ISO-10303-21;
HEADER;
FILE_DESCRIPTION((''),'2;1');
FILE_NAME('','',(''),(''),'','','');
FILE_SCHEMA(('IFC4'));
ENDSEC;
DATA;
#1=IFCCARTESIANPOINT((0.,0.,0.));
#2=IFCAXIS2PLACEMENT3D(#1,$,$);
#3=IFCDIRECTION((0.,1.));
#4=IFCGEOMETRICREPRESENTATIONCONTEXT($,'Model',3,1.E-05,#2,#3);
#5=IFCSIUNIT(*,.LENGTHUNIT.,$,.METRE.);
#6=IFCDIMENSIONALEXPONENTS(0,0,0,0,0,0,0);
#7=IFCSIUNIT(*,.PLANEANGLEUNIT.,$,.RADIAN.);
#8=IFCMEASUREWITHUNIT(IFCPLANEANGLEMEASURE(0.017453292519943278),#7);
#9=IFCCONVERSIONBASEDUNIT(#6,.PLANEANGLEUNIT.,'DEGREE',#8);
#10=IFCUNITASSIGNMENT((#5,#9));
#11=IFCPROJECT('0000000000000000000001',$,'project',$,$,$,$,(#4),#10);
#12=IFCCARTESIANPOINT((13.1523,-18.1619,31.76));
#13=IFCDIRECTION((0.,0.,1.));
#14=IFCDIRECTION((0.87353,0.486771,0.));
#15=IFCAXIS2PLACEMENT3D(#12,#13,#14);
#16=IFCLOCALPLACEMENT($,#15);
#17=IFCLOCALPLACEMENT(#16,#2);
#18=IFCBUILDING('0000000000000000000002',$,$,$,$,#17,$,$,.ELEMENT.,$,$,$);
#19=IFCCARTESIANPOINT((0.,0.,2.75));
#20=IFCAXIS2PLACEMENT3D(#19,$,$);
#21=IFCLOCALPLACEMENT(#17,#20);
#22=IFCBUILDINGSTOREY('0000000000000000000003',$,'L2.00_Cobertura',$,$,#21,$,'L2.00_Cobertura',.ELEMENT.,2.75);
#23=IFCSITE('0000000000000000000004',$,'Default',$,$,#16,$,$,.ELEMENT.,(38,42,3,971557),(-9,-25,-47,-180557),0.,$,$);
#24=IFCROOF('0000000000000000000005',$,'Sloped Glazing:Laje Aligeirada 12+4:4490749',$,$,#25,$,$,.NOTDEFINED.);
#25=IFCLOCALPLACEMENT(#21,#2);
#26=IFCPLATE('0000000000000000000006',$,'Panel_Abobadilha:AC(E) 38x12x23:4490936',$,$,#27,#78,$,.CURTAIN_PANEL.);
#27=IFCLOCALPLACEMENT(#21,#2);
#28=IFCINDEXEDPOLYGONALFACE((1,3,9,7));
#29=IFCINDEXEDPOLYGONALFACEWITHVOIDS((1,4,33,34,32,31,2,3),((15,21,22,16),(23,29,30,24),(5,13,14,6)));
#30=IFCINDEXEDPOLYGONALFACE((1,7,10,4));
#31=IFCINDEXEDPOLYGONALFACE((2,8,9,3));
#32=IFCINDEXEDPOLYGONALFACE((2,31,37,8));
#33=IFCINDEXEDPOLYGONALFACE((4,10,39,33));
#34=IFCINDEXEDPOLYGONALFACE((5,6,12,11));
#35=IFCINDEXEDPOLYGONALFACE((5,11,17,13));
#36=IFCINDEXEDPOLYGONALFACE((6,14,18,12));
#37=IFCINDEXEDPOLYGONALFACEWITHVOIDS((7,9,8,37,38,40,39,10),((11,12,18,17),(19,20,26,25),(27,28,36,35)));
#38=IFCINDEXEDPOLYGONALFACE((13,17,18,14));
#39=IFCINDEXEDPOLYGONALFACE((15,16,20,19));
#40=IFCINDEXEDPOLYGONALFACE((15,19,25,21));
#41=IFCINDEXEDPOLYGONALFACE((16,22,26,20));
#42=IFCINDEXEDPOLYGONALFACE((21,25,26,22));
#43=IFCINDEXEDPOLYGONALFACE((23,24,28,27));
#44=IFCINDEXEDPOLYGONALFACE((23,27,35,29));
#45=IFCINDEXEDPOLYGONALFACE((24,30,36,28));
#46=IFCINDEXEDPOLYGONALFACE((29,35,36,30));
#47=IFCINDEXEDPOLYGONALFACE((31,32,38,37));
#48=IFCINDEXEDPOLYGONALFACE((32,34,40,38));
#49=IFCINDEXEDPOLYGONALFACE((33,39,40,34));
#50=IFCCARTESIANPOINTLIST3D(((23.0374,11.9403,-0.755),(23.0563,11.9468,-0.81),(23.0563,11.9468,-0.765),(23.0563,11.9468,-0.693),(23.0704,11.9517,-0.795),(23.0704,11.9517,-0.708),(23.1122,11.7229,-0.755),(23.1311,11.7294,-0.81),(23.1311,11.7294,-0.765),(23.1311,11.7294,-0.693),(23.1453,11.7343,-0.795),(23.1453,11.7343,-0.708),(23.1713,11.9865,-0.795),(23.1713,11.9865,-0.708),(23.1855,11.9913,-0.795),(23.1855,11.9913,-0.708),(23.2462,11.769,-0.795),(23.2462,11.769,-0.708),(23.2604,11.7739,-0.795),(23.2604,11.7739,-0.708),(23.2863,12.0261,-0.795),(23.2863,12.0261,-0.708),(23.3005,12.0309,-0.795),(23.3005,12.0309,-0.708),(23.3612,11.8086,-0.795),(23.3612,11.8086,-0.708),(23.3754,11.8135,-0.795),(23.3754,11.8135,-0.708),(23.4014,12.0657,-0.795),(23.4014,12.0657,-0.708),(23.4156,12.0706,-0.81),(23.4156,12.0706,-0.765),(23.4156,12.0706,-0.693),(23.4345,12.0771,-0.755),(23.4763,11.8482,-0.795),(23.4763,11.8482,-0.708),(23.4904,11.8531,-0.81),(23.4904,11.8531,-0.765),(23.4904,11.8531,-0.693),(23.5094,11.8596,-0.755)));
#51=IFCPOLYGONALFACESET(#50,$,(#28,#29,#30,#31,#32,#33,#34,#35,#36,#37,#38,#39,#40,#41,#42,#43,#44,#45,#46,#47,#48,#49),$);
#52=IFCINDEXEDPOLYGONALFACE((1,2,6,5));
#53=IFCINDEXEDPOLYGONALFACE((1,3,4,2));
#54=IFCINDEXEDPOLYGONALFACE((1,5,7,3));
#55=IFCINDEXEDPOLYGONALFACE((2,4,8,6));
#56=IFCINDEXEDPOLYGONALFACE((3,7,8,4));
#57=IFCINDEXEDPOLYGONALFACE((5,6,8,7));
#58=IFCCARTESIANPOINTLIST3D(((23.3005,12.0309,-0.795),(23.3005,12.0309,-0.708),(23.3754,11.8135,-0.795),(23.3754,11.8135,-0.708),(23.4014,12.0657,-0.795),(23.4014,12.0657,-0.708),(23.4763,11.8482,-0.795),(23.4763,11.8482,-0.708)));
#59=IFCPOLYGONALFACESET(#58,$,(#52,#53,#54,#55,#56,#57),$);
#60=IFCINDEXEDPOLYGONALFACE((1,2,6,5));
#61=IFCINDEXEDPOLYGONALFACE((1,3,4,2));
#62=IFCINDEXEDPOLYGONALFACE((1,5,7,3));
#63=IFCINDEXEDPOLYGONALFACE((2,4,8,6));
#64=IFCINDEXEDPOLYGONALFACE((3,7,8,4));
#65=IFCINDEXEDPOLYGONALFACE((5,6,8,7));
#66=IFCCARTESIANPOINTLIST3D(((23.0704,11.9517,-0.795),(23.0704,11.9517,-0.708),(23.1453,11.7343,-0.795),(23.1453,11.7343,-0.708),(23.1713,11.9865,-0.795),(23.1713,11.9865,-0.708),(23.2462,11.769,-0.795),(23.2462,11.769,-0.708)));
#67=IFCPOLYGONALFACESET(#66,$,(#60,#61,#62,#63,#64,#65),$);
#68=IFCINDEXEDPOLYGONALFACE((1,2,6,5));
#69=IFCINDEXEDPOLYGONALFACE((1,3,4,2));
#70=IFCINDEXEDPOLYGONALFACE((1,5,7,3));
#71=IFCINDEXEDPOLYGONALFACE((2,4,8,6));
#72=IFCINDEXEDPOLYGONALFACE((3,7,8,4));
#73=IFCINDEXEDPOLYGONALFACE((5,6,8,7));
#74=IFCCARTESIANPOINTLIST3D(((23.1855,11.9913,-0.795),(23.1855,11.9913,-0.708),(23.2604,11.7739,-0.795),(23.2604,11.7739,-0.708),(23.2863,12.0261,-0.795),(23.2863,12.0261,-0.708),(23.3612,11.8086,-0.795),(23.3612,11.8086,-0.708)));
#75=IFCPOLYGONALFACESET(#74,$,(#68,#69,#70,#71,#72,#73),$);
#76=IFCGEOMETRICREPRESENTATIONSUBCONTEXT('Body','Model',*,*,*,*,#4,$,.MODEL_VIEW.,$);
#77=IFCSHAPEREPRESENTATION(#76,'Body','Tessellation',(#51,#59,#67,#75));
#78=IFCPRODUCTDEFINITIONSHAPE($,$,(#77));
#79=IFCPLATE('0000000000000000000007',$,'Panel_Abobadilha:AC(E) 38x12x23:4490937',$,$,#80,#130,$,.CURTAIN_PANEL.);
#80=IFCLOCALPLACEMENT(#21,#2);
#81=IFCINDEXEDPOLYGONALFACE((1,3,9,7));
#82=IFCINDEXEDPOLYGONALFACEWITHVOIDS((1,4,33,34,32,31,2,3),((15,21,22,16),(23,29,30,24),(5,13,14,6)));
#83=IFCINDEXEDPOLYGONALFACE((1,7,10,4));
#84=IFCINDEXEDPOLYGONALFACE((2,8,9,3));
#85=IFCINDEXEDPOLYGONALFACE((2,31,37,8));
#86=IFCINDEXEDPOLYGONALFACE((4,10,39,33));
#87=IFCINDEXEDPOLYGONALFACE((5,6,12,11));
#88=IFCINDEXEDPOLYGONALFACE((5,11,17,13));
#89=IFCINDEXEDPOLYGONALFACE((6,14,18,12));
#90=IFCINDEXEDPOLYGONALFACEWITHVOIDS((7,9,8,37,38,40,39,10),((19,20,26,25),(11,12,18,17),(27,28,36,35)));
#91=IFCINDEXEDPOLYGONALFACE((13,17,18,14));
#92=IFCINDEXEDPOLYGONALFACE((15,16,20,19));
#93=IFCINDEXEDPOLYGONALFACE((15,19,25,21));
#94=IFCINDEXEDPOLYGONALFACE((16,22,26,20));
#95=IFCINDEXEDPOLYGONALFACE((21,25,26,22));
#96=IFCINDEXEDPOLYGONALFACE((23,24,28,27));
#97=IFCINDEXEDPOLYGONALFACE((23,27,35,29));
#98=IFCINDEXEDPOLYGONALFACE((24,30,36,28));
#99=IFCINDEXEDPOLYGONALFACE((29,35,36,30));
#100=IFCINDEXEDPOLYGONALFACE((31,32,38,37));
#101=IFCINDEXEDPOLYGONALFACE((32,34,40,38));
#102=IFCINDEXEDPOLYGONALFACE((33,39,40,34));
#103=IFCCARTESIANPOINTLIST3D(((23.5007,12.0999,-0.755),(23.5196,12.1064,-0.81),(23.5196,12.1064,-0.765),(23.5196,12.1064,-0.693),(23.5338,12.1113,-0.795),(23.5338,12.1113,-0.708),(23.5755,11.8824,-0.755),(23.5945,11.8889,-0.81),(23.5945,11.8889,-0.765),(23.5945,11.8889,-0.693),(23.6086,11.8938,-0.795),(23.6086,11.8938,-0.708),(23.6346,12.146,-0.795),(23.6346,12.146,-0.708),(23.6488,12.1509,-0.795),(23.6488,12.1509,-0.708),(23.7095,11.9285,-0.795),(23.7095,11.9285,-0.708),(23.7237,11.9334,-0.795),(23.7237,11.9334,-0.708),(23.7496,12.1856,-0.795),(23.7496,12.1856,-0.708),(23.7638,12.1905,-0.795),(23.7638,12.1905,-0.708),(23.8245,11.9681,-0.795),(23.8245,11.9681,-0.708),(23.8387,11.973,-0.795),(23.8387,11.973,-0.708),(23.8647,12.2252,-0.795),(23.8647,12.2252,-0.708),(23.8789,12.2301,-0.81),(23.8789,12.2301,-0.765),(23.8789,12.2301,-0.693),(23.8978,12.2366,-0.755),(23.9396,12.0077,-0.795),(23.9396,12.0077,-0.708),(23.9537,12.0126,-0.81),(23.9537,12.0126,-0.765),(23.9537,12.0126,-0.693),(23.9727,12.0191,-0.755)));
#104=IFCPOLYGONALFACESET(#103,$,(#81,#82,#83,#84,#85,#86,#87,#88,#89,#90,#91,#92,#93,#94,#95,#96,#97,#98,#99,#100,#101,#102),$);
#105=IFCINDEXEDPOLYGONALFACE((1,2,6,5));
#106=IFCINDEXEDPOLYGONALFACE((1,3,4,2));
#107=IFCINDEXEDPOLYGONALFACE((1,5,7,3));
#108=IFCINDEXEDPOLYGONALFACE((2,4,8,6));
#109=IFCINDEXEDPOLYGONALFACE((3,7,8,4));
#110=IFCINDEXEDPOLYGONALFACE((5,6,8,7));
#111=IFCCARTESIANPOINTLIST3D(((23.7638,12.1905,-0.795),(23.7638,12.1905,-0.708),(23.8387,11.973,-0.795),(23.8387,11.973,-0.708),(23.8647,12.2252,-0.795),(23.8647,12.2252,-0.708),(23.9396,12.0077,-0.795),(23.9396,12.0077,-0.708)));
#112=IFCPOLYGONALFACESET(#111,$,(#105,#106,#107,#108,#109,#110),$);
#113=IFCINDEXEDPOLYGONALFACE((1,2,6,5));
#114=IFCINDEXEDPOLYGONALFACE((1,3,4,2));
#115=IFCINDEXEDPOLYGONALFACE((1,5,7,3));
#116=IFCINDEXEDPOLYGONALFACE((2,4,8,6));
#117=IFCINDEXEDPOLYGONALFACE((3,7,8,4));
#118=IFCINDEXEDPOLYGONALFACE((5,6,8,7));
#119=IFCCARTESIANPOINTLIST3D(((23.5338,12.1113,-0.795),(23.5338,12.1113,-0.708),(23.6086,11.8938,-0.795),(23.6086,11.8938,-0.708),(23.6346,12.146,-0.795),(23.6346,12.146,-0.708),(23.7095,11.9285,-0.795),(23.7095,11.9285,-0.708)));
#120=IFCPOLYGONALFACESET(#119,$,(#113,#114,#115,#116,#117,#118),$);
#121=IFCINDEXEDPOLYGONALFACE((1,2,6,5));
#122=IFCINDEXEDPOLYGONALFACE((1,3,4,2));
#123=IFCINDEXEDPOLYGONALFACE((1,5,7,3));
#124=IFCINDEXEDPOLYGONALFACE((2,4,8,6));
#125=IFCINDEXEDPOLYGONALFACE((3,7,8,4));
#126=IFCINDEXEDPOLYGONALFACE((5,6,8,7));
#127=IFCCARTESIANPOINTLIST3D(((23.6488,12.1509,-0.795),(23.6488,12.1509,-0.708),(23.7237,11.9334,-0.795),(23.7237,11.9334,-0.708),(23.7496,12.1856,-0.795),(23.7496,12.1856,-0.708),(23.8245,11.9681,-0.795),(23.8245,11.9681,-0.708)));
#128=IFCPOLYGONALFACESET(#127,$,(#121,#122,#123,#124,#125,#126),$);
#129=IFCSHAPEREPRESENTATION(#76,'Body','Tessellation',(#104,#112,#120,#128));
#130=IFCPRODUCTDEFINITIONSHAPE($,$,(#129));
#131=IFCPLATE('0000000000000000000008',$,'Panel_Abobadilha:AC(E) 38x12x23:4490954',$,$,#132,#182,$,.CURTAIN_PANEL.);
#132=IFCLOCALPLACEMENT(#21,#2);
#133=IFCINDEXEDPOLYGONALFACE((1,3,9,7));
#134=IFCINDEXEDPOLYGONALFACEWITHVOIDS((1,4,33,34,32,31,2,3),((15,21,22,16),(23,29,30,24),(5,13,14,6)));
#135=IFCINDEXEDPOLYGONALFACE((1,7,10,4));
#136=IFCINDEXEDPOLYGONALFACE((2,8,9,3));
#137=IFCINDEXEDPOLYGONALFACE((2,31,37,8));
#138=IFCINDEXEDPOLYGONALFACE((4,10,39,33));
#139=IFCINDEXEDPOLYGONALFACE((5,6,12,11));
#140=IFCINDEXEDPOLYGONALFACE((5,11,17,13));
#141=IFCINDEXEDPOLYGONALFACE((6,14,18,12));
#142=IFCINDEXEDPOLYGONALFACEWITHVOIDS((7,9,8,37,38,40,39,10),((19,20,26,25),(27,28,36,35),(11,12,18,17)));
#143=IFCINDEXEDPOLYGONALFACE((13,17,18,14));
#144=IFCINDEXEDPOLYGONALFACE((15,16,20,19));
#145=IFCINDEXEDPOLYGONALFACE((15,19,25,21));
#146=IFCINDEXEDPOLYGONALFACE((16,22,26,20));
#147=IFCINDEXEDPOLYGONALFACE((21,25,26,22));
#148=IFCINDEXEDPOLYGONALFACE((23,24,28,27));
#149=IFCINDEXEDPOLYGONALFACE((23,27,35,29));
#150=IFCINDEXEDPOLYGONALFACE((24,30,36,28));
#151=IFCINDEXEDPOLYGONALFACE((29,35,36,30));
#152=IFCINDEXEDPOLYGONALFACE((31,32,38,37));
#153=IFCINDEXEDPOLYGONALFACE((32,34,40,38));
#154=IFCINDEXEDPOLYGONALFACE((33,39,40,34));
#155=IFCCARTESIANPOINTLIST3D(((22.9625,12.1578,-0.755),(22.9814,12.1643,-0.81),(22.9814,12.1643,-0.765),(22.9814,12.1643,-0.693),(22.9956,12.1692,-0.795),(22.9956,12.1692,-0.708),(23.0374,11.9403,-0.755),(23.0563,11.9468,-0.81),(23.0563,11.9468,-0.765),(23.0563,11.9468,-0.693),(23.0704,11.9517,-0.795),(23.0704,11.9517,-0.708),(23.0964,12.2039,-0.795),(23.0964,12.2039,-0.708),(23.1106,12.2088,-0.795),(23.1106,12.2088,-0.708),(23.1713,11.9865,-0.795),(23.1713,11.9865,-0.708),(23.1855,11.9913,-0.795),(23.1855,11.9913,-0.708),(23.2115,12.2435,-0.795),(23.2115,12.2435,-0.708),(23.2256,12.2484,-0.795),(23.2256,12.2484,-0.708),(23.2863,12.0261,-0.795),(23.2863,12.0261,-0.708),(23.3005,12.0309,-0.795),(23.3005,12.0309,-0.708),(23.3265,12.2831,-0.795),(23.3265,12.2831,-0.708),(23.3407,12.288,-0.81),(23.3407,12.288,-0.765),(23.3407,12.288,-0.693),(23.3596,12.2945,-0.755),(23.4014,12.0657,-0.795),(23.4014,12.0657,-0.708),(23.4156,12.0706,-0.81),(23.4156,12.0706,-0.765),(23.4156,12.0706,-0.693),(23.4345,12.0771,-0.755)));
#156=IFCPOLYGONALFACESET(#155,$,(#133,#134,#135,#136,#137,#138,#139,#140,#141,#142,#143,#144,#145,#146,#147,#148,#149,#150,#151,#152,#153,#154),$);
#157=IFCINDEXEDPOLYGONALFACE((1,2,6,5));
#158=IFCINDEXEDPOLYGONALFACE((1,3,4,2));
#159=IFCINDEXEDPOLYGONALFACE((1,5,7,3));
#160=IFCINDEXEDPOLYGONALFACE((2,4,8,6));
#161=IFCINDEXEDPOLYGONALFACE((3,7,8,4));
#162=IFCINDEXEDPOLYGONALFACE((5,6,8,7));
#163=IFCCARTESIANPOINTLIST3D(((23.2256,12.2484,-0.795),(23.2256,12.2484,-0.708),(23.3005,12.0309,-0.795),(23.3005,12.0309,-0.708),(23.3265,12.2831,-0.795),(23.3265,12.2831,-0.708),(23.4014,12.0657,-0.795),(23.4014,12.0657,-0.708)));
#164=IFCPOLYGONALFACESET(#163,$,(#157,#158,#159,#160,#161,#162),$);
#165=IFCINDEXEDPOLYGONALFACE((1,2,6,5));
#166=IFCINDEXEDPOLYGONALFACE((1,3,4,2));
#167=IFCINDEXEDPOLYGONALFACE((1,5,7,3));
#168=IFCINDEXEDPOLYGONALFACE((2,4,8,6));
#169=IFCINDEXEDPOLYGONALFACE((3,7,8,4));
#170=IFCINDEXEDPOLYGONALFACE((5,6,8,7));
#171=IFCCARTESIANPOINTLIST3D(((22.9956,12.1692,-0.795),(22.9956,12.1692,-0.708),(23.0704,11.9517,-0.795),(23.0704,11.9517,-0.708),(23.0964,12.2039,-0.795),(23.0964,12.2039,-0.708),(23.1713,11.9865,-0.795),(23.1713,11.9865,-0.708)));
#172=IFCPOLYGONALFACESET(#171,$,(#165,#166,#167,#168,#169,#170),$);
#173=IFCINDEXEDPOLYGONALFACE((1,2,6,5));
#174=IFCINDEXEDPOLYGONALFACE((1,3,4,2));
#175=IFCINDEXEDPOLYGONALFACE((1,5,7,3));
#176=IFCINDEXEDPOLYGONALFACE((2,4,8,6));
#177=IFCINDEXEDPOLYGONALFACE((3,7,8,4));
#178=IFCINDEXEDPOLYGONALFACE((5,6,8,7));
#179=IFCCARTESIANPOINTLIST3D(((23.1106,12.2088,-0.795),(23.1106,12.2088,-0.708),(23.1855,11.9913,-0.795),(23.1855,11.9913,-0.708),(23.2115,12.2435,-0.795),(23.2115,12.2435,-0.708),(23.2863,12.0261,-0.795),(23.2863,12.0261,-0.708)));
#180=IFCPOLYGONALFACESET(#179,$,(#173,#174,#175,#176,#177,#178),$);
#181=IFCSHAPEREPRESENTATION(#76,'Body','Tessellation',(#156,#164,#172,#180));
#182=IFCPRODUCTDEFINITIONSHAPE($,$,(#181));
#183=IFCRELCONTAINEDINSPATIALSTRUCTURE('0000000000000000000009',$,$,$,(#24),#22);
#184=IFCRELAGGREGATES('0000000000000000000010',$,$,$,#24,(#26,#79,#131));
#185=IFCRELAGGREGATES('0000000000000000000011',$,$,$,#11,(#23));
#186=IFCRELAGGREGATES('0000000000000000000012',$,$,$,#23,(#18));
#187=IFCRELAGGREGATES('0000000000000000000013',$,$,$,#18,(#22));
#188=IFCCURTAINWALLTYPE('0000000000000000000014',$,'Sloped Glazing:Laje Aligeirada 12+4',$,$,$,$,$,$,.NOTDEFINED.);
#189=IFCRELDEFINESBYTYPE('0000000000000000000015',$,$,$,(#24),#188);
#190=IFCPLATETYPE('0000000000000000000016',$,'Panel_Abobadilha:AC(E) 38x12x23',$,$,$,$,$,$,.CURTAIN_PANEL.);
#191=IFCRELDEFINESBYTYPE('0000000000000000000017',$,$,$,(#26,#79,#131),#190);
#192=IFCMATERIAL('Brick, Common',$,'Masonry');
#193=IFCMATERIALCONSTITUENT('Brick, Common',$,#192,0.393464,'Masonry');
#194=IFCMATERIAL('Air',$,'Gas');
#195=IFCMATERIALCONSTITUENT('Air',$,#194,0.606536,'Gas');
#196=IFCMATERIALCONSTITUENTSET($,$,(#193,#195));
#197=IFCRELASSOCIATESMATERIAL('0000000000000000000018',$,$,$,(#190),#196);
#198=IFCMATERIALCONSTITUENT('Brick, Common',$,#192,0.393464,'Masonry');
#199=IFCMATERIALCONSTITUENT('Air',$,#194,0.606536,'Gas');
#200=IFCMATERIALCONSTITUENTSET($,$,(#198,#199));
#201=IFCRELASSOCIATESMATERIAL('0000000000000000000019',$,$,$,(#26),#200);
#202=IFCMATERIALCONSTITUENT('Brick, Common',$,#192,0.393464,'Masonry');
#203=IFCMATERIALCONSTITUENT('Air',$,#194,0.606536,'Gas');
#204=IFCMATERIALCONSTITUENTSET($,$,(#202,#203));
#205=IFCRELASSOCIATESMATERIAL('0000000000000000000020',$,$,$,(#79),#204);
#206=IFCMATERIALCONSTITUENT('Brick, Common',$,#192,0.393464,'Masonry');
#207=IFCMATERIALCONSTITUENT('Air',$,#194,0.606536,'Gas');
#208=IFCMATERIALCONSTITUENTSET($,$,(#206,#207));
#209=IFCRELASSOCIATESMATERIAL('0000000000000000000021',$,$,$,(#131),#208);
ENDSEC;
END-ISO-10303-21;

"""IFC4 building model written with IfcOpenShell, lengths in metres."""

from ifc_helpers import new_model, entity, si_unit, converted_unit, direction, frame, origin, place, context, subcontext, project, spatial, indexed_curve, outline, extrude, source, transform, mapped, material, constituent, constituent_set, type_object, type_shapes, element, aggregate, save


model = new_model("IFC4")

# Units and contexts
model_context = context("Model", 3, precision=1e-05, world=origin(), true_north=direction((0.0, 1.0)))
body_context = subcontext(model_context, "Body", "Model", "MODEL_VIEW")
ifc_project = project(units=[si_unit("LENGTHUNIT", "METRE"), converted_unit("PLANEANGLEUNIT", "DEGREE", entity("IfcPlaneAngleMeasure", 0.017453292519943278), si_unit("PLANEANGLEUNIT", "RADIAN"), dimensions=[0, 0, 0, 0, 0, 0, 0])], contexts=[model_context])

# Site, building, storey
site_placement = place(None, frame((13.1523, -18.1619, 31.76), z_axis=(0.0, 0.0, 1.0), x_axis=(0.87353, 0.486771, 0.0)))
site = spatial("IfcSite", under=ifc_project, at=site_placement, Name="Default", CompositionType="ELEMENT", RefLatitude=(38, 42, 3, 971557), RefLongitude=(-9, -25, -47, -180557), RefElevation=0.0)
building_placement = place(site_placement, origin())
building = spatial("IfcBuilding", under=site, at=building_placement, CompositionType="ELEMENT")
storey_placement = place(building_placement, frame((0.0, 0.0, 2.75)))
storey = spatial("IfcBuildingStorey", under=building, at=storey_placement, Name="L2.00_Cobertura", LongName="L2.00_Cobertura", CompositionType="ELEMENT", Elevation=2.75)

# Roof, plates
curtain_wall_type = type_object("IfcCurtainWallType", Name="Sloped Glazing:Laje Aligeirada 12+4", PredefinedType="NOTDEFINED")
roof_placement = place(storey_placement, frame((0.0, 0.0, -2.75)))
roof = element("IfcRoof", 1, at=roof_placement, inside=storey, type_object=curtain_wall_type, Name="Sloped Glazing:Laje Aligeirada 12+4:4490749", PredefinedType="NOTDEFINED")
ifc_material_1 = material(Name="Brick, Common", Category="Masonry")
ifc_material_2 = material(Name="Air", Category="Gas")
ifc_constituent_1 = constituent(ifc_material_1, Name="Brick, Common", Category="Masonry", fraction=0.393464)
ifc_constituent_2 = constituent(ifc_material_2, Name="Air", Category="Gas", fraction=0.606536)
ifc_constituent_set_1 = constituent_set(constituents=[ifc_constituent_1, ifc_constituent_2])
plate_type_1 = type_object("IfcPlateType", Name="Panel_Abobadilha:AC(E) 38x12x23", PredefinedType="CURTAIN_PANEL", material=ifc_constituent_set_1)
shared_shape_1 = source(origin(), body_context, "Body", "SweptSolid", [
    extrude(outline(indexed_curve([(-0.19, -0.0543), (0.19, -0.0543), (0.19, -0.0093), (0.21, 0.0007), (0.19, 0.0628), (-0.19, 0.0628), (-0.21, 0.0007), (-0.19, -0.0093), (-0.19, -0.0543)], self_intersect=False), holes=[indexed_curve([(-0.0683, 0.0477), (-0.0683, -0.0393), (-0.175, -0.0393), (-0.175, 0.0477), (-0.0683, 0.0477)], self_intersect=False), indexed_curve([(0.0533, 0.0477), (0.0533, -0.0393), (-0.0533, -0.0393), (-0.0533, 0.0477), (0.0533, 0.0477)], self_intersect=False), indexed_curve([(0.175, 0.0477), (0.175, -0.0393), (0.0683, -0.0393), (0.0683, 0.0477), (0.175, 0.0477)], self_intersect=False)]), frame((0.0, 0.0543, 0.0)), (0.0, 0.0, 1.0), 0.23),
    extrude(outline(indexed_curve([(-0.0533, -0.0435), (0.0533, -0.0435), (0.0533, 0.0435), (-0.0533, 0.0435), (-0.0533, -0.0435)], self_intersect=False)), frame((0.1217, 0.0585, 0.0), z_axis=(0.0, 0.0, 1.0), x_axis=(-1.0, 0.0, 0.0)), (0.0, 0.0, 1.0), 0.23),
    extrude(outline(indexed_curve([(-0.0533, -0.0435), (0.0533, -0.0435), (0.0533, 0.0435), (-0.0533, 0.0435), (-0.0533, -0.0435)], self_intersect=False)), frame((-0.1217, 0.0585, 0.0), z_axis=(0.0, 0.0, 1.0), x_axis=(-1.0, 0.0, 0.0)), (0.0, 0.0, 1.0), 0.23),
    extrude(outline(indexed_curve([(-0.0533, -0.0435), (0.0533, -0.0435), (0.0533, 0.0435), (-0.0533, 0.0435), (-0.0533, -0.0435)], self_intersect=False)), frame((0.0, 0.0585, 0.0), z_axis=(0.0, 0.0, 1.0), x_axis=(-1.0, 0.0, 0.0)), (0.0, 0.0, 1.0), 0.23),
])
type_shapes(plate_type_1, [shared_shape_1])
ifc_constituent_3 = constituent(ifc_material_1, Name="Brick, Common", Category="Masonry", fraction=0.393464)
ifc_constituent_4 = constituent(ifc_material_2, Name="Air", Category="Gas", fraction=0.606536)
ifc_constituent_set_2 = constituent_set(constituents=[ifc_constituent_3, ifc_constituent_4])
plate_1_placement = place(roof_placement, frame((23.2359, 12.0087, 1.94), z_axis=(0.325568, -0.945519, 0.0), x_axis=(0.945519, 0.325568, 0.0)))
plate_1 = element("IfcPlate", 2, at=plate_1_placement, type_object=plate_type_1, material=ifc_constituent_set_2, Name="Panel_Abobadilha:AC(E) 38x12x23:4490936", PredefinedType="CURTAIN_PANEL", context=body_context, shape_type="MappedRepresentation", body=[
    mapped(shared_shape_1, transform((0.0, 0.0, 0.0), scale=1.0)),
])
ifc_constituent_5 = constituent(ifc_material_1, Name="Brick, Common", Category="Masonry", fraction=0.393464)
ifc_constituent_6 = constituent(ifc_material_2, Name="Air", Category="Gas", fraction=0.606536)
ifc_constituent_set_3 = constituent_set(constituents=[ifc_constituent_5, ifc_constituent_6])
plate_2_placement = place(roof_placement, frame((23.6992, 12.1682, 1.94), z_axis=(0.325568, -0.945519, 0.0), x_axis=(0.945519, 0.325568, 0.0)))
plate_2 = element("IfcPlate", 3, at=plate_2_placement, type_object=plate_type_1, material=ifc_constituent_set_3, Name="Panel_Abobadilha:AC(E) 38x12x23:4490937", PredefinedType="CURTAIN_PANEL", context=body_context, shape_type="MappedRepresentation", body=[
    mapped(shared_shape_1, transform((0.0, 0.0, 0.0), scale=1.0)),
])
ifc_constituent_7 = constituent(ifc_material_1, Name="Brick, Common", Category="Masonry", fraction=0.393464)
ifc_constituent_8 = constituent(ifc_material_2, Name="Air", Category="Gas", fraction=0.606536)
ifc_constituent_set_4 = constituent_set(constituents=[ifc_constituent_7, ifc_constituent_8])
plate_3_placement = place(roof_placement, frame((23.161, 12.2262, 1.94), z_axis=(0.325568, -0.945519, 0.0), x_axis=(0.945519, 0.325568, 0.0)))
plate_3 = element("IfcPlate", 4, at=plate_3_placement, type_object=plate_type_1, material=ifc_constituent_set_4, Name="Panel_Abobadilha:AC(E) 38x12x23:4490954", PredefinedType="CURTAIN_PANEL", context=body_context, shape_type="MappedRepresentation", body=[
    mapped(shared_shape_1, transform((0.0, 0.0, 0.0), scale=1.0)),
])
aggregate(roof, [plate_1, plate_2, plate_3])

save(model, "model.ifc")
